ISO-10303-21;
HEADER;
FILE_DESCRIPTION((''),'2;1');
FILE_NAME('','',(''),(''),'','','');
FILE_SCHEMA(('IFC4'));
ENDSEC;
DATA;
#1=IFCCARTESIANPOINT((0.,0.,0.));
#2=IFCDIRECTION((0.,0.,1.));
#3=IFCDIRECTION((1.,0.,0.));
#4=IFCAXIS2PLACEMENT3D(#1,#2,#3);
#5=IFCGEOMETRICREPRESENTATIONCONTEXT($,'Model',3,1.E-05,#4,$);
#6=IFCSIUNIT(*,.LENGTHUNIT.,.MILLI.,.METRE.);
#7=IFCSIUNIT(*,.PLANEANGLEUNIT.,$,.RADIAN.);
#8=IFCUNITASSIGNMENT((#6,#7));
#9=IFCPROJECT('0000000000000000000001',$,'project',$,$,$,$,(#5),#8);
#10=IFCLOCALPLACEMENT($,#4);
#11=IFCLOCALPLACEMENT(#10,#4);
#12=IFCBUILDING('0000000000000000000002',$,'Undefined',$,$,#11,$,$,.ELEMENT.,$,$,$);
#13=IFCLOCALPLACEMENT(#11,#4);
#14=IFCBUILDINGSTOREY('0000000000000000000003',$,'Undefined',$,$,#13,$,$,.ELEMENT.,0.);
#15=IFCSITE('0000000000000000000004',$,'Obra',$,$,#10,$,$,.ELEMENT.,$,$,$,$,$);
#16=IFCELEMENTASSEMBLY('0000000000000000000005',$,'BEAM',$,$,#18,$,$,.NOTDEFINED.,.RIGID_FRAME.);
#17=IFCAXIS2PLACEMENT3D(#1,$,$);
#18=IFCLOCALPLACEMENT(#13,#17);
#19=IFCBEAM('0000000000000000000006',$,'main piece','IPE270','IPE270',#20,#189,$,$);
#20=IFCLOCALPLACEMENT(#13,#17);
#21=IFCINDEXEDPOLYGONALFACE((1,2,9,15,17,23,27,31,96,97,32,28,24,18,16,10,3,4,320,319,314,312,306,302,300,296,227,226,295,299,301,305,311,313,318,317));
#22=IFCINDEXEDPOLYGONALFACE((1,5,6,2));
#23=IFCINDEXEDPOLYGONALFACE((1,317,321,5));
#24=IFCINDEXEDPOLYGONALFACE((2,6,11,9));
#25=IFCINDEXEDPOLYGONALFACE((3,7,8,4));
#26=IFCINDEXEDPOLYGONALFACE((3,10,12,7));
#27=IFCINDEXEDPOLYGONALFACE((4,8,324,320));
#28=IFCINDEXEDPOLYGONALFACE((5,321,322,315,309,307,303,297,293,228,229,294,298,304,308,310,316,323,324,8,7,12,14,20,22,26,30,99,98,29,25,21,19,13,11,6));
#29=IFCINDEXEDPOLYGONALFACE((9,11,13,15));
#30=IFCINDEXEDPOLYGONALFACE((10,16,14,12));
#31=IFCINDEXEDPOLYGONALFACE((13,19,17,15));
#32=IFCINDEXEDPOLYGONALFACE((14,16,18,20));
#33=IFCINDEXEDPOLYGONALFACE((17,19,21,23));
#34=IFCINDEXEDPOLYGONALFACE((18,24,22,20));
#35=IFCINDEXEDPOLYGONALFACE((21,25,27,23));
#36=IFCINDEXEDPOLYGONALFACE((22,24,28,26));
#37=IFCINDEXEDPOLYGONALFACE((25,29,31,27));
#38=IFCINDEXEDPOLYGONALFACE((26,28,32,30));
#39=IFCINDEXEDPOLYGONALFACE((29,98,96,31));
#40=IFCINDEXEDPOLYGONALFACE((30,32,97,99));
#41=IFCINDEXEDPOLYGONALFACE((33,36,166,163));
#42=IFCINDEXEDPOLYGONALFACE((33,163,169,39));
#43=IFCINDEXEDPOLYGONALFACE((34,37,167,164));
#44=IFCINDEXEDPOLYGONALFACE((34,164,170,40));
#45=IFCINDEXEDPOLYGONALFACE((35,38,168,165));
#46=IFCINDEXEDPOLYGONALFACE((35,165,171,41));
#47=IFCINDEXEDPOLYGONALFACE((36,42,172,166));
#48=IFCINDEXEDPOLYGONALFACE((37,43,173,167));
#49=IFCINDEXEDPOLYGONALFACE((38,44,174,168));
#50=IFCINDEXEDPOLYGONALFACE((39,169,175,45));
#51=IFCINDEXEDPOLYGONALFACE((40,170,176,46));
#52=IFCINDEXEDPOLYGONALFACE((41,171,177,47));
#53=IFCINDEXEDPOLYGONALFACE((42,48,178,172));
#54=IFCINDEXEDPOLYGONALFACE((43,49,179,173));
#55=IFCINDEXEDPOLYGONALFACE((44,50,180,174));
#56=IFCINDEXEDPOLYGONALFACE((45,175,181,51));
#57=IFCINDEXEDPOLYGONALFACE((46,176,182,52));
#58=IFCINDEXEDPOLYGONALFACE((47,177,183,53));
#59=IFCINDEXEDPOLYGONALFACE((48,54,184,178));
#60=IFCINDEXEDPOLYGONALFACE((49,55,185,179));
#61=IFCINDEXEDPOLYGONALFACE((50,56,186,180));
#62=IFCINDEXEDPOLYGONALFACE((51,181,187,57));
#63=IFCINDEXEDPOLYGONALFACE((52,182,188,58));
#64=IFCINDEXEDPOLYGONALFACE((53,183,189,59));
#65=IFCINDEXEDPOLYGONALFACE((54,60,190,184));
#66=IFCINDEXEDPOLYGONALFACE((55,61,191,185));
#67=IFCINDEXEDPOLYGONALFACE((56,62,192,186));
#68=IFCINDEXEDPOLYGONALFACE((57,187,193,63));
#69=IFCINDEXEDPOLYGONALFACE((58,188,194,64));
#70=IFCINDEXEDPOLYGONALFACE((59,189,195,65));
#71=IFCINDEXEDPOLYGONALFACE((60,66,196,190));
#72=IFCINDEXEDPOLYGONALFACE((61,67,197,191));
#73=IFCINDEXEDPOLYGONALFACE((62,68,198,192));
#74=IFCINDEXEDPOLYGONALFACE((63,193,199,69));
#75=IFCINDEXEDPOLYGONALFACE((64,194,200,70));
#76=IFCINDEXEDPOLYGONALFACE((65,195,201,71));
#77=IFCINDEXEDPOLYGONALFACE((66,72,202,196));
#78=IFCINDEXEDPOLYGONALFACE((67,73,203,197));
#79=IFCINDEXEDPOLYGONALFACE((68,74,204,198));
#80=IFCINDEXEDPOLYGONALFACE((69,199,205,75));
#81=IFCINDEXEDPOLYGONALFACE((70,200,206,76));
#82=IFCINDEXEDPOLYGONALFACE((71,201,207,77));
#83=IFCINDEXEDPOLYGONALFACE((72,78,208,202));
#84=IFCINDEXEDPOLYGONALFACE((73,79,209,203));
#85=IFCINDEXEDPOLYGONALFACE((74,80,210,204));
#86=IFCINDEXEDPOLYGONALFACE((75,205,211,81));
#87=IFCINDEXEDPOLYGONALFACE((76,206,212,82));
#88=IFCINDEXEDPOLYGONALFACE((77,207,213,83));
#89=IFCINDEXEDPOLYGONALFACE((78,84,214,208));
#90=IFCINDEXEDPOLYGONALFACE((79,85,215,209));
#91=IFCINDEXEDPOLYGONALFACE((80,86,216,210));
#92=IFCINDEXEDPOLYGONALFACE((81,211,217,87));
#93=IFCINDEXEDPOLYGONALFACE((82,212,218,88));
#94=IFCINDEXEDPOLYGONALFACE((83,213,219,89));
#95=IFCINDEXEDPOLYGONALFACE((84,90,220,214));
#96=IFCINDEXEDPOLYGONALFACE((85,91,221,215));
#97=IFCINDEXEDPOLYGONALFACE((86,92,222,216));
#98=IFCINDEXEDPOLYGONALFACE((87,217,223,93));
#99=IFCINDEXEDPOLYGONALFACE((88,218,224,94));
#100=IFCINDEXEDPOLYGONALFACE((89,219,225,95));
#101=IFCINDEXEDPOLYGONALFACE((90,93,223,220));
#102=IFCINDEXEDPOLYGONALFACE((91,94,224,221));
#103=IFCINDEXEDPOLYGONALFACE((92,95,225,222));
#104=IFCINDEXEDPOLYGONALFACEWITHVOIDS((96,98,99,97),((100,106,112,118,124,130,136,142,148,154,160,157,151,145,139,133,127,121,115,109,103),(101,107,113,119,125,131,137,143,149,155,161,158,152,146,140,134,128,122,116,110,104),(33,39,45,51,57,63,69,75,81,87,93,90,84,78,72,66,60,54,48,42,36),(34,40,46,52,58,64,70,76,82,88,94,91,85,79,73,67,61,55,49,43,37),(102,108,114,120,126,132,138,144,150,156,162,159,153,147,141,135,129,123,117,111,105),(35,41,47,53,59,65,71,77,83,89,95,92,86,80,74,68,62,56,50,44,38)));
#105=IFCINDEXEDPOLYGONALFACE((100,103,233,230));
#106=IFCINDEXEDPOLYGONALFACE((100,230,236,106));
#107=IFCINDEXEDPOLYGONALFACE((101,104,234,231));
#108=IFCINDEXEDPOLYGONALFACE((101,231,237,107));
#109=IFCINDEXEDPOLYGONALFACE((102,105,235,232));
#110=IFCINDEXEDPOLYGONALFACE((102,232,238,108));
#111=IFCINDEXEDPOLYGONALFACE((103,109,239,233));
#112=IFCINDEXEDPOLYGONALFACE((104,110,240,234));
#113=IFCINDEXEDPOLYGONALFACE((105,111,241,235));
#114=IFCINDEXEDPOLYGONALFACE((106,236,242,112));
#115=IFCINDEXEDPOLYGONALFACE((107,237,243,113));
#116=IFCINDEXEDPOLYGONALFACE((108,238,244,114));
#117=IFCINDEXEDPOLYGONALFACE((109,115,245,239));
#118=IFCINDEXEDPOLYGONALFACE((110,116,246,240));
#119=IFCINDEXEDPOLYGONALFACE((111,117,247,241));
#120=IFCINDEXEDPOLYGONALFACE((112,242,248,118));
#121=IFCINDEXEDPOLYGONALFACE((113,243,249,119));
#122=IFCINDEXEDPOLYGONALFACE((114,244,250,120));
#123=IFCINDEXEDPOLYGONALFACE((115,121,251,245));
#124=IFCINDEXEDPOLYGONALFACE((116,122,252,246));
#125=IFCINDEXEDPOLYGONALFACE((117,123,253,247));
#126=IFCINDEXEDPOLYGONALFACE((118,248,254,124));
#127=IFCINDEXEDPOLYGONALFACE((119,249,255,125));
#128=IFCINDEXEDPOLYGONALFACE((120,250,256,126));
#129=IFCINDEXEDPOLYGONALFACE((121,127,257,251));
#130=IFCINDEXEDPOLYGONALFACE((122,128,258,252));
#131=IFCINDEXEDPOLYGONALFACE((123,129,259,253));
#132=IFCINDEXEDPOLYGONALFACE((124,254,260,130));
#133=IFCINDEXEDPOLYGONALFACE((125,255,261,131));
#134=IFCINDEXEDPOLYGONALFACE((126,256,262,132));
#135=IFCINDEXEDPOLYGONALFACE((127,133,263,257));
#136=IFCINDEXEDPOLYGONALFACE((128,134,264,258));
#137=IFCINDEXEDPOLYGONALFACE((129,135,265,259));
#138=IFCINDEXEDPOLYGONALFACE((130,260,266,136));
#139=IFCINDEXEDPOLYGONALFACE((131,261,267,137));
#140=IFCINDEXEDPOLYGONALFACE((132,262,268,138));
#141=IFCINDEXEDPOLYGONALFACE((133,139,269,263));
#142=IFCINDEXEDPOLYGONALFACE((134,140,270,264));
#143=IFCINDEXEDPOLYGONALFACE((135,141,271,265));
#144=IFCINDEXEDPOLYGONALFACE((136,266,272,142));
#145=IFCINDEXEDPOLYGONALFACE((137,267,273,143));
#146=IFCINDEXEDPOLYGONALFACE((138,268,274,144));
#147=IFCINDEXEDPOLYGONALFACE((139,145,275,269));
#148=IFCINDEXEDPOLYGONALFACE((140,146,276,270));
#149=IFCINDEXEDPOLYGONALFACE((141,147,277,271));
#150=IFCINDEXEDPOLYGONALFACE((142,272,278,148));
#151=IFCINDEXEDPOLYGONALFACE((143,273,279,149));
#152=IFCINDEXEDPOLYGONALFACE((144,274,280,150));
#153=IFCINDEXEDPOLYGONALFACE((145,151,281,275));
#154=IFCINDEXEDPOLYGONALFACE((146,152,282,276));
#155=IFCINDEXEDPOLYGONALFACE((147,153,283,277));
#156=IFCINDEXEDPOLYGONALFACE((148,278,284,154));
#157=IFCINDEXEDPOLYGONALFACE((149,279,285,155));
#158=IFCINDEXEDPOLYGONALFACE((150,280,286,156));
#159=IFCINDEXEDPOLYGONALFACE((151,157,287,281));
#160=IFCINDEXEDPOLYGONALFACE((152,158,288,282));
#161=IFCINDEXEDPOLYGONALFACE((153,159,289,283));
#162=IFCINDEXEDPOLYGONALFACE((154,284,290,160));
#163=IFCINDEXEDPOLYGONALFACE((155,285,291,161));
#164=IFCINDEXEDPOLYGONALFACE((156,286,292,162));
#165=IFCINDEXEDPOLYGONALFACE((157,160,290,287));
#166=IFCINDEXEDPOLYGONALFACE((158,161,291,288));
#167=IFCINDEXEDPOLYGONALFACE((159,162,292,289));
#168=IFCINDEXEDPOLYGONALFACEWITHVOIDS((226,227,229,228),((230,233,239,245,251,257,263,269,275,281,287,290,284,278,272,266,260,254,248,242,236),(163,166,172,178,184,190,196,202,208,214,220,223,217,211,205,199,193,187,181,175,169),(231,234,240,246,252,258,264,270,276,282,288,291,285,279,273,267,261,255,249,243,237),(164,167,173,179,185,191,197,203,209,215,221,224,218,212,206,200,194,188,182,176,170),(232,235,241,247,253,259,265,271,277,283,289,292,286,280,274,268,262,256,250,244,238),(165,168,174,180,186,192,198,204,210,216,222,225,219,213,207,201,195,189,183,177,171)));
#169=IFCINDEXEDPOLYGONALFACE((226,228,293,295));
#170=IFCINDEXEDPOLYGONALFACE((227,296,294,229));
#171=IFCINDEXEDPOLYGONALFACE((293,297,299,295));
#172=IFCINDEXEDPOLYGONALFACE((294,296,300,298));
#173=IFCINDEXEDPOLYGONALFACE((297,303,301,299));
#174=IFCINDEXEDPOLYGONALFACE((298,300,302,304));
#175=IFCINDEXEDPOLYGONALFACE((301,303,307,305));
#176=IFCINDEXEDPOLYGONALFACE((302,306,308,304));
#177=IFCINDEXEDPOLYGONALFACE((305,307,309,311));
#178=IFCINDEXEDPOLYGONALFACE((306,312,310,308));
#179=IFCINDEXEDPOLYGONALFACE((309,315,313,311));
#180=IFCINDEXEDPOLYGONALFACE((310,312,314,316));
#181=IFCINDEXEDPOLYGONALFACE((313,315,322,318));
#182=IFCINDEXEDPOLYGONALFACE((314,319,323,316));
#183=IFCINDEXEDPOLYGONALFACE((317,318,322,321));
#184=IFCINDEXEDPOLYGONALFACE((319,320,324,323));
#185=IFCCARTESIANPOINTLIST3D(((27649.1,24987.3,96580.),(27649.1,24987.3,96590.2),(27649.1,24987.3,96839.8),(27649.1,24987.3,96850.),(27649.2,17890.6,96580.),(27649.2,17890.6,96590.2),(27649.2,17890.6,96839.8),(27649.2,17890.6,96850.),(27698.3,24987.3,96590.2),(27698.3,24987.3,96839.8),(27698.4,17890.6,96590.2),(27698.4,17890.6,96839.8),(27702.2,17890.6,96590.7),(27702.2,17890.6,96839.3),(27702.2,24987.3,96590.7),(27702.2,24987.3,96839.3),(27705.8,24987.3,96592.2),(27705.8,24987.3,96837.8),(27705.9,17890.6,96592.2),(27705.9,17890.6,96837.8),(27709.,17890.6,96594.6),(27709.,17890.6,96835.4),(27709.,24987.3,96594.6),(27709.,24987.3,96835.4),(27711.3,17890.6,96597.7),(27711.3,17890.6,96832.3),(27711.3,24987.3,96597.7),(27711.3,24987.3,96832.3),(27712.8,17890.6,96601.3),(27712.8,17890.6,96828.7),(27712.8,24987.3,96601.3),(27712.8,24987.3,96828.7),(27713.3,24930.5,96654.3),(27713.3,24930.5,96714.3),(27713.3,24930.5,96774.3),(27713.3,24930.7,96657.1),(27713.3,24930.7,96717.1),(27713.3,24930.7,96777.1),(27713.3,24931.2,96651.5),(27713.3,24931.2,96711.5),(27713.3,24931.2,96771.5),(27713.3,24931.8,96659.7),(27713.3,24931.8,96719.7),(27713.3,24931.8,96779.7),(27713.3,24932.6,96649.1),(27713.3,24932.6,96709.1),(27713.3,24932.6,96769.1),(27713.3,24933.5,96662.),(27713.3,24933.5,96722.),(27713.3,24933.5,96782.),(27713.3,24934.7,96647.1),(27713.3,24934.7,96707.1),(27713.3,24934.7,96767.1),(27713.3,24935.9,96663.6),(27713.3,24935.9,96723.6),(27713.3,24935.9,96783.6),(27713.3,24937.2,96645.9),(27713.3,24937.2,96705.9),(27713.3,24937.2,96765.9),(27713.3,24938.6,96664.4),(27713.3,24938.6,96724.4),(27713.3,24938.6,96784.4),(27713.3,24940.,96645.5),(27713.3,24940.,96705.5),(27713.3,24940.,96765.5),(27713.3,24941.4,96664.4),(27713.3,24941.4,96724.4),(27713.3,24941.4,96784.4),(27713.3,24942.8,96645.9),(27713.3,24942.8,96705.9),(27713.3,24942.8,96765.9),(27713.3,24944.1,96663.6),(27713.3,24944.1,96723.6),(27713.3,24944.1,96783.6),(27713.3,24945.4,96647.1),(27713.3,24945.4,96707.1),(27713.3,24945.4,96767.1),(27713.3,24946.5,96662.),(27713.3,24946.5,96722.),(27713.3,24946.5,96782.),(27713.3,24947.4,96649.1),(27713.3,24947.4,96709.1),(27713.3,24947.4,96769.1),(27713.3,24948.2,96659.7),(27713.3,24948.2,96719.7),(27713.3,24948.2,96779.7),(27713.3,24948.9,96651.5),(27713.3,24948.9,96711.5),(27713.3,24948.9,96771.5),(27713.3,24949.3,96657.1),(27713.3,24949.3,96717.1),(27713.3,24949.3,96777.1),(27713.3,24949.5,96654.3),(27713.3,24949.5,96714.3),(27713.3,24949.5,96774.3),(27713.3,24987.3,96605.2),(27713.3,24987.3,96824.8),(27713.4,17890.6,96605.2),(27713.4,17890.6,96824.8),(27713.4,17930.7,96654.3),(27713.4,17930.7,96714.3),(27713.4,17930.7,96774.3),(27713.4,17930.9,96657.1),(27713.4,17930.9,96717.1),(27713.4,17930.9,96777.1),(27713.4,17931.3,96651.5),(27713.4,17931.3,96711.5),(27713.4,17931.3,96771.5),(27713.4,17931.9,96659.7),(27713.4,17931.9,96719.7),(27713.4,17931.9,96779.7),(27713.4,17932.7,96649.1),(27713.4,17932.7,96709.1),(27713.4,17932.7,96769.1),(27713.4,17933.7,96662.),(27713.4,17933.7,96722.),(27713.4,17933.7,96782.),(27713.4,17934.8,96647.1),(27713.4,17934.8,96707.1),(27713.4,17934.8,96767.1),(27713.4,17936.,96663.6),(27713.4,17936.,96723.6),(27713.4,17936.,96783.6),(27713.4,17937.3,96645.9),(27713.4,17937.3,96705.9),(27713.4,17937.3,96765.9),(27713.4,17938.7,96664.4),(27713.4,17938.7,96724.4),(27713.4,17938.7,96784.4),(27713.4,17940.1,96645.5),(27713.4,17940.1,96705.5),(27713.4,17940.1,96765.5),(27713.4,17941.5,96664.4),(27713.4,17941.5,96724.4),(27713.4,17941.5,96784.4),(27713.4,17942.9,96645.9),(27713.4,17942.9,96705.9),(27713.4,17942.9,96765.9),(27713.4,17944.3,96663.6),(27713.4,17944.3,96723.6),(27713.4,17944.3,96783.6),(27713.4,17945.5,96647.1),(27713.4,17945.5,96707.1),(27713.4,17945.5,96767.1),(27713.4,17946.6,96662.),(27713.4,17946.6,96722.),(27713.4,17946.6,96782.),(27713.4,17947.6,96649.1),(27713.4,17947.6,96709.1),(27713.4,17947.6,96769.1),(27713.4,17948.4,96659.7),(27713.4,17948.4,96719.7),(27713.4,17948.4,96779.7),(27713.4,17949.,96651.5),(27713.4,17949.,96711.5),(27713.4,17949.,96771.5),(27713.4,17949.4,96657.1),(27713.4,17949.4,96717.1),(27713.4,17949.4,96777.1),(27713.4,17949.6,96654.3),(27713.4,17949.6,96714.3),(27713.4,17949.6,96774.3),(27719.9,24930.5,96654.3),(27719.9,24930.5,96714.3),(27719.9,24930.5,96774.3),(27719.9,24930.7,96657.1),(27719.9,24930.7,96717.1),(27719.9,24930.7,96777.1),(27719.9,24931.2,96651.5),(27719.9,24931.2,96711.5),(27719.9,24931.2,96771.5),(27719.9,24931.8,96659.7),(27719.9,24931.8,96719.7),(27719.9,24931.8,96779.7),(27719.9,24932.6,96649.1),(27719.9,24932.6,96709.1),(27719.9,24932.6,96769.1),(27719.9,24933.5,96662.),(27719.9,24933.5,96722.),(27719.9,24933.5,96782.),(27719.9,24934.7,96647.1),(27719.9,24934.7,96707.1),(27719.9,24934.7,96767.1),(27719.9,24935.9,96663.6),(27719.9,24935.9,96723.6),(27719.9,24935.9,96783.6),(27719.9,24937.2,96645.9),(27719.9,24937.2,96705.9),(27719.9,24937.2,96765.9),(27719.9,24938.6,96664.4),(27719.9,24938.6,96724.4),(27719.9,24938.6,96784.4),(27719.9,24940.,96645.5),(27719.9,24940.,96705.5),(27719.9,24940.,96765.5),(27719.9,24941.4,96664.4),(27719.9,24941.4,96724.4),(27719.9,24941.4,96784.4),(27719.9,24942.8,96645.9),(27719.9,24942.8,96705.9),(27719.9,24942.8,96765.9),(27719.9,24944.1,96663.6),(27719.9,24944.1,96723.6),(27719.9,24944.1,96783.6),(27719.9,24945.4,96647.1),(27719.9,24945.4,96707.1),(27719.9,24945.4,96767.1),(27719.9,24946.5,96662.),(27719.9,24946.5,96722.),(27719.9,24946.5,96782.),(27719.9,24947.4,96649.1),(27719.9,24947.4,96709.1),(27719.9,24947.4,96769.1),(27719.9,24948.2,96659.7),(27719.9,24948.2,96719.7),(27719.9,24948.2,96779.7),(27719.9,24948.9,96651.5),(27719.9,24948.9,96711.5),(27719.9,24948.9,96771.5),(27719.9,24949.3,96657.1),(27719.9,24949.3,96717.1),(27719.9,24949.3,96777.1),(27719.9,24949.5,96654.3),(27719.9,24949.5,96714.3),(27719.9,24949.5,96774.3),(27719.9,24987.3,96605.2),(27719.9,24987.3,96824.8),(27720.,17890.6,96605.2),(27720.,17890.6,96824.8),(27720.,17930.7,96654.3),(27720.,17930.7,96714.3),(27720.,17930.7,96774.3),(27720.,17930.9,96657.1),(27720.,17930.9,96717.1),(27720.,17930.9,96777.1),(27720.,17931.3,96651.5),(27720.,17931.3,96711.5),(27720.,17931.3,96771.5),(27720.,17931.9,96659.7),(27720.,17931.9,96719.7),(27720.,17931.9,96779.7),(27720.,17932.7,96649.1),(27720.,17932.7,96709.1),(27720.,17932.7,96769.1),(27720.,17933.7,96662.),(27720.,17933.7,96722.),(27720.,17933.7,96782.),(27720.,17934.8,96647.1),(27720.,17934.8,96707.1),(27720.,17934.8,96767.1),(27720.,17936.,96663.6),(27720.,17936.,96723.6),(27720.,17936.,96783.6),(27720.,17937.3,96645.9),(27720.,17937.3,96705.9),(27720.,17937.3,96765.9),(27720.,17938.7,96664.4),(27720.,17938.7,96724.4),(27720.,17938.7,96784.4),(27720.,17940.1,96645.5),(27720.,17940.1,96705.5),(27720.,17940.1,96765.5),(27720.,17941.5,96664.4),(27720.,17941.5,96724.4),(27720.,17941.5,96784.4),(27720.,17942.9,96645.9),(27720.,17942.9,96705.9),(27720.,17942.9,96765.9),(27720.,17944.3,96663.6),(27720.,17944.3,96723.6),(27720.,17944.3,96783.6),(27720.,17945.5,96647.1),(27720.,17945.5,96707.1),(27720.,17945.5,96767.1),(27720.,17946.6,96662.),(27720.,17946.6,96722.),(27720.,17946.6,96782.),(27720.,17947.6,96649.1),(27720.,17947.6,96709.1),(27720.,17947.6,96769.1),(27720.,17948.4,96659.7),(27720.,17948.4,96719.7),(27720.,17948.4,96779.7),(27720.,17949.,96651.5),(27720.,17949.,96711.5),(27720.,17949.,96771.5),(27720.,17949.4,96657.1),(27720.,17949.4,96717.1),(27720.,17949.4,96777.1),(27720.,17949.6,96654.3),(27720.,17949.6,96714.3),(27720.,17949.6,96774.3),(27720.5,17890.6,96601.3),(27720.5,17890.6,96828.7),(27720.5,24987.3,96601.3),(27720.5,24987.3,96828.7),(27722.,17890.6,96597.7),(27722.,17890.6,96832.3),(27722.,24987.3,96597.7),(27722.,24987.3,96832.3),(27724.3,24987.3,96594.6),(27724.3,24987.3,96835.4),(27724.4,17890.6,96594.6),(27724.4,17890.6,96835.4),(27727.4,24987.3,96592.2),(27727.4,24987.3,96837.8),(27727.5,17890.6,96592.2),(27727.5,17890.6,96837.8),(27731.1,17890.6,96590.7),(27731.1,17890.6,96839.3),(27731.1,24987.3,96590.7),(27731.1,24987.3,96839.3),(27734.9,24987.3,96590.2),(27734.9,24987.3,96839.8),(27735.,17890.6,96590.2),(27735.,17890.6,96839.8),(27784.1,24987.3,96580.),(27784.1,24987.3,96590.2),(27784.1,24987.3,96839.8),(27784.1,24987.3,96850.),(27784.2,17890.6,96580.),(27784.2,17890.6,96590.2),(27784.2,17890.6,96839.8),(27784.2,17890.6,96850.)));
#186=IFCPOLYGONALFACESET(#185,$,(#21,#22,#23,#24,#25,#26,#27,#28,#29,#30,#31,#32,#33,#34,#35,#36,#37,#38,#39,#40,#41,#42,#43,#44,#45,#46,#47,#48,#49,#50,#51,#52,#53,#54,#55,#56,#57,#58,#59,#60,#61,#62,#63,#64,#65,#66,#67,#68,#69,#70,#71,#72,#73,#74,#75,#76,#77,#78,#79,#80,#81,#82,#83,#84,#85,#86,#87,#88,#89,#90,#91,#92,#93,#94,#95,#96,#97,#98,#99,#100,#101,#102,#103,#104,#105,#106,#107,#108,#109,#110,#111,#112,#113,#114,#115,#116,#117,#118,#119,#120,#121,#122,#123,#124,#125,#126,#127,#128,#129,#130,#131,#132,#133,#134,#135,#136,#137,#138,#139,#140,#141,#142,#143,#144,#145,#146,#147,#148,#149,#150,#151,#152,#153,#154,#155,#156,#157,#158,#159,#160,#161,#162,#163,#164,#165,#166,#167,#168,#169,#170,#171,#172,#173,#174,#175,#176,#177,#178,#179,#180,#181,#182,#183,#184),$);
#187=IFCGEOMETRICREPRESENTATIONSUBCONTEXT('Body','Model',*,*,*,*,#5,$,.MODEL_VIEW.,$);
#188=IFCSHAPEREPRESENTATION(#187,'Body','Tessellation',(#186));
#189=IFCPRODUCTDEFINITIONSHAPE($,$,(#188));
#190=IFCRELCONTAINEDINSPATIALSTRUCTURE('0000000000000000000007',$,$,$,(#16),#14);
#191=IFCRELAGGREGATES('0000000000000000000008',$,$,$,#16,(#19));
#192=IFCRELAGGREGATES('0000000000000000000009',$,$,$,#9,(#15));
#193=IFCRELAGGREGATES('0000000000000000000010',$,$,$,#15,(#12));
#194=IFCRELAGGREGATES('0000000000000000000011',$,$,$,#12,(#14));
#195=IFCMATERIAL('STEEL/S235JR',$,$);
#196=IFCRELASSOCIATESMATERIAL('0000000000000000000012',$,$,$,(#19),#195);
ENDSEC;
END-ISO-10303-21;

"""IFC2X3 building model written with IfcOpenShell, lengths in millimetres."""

from ifc_helpers import new_model, si_unit, frame, origin_with_axes, origin_2d_with_axis, place, context, subcontext, project, spatial, circle, i_section, extrude, clip, halfspace, source, transform, mapped, material, element, aggregate, save


model = new_model("IFC2X3")

# Units and contexts
model_context = context("Model", 3, precision=1e-05, world=origin_with_axes())
body_context = subcontext(model_context, "Body", "Model", "MODEL_VIEW")
ifc_project = project(units=[si_unit("LENGTHUNIT", "METRE", prefix="MILLI"), si_unit("PLANEANGLEUNIT", "RADIAN")], contexts=[model_context])

# Site, building, storey
site_placement = place(None, origin_with_axes())
site = spatial("IfcSite", under=ifc_project, at=site_placement, Name="Obra", CompositionType="ELEMENT")
building_placement = place(site_placement, origin_with_axes())
building = spatial("IfcBuilding", under=site, at=building_placement, Name="Undefined", CompositionType="ELEMENT")
storey_placement = place(building_placement, origin_with_axes())
storey = spatial("IfcBuildingStorey", under=building, at=storey_placement, Name="Undefined", CompositionType="ELEMENT", Elevation=0.0)

# Shared definitions
ifc_material = material(Name="STEEL/S235JR")

# Element assembly, beam, openings
assembly_1_placement = place(storey_placement, origin_with_axes())
assembly_1 = element("IfcElementAssembly", 1, at=assembly_1_placement, inside=storey, Name="BEAM", AssemblyPlace="NOTDEFINED", PredefinedType="RIGID_FRAME")
beam_1_placement = place(assembly_1_placement, frame((27716.7, 17630.1, 96715.0), z_axis=(0.0, 0.0, 1.0), x_axis=(-0.000002, 1.0, 0.0)))
beam_1 = element("IfcBeam", 2, at=beam_1_placement, material=ifc_material, Name="main piece", Description="IPE270", ObjectType="IPE270", context=body_context, shape_type="Clipping", body=[
    clip(clip(extrude(i_section(OverallWidth=135.0, OverallDepth=270.0, WebThickness=6.6, FlangeThickness=10.2, FilletRadius=15.0, at=origin_2d_with_axis()), frame((7357.1, 0.0, 0.0), z_axis=(-1.0, 0.0, 0.0), x_axis=(0.0, -1.0, 0.0)), (0.0, 0.0, 1.0), 7357.1), halfspace(frame((260.5, 60.0, -120.0), z_axis=(-1.0, -0.000017, 0.0), x_axis=(0.0, 0.0, 1.0)), False)), halfspace(frame((7359.4, -60.0, -120.0), z_axis=(1.0, 0.000019, 0.0), x_axis=(0.0, 0.0, 1.0)), False)),
])
shared_shape_1 = source(origin_with_axes(), body_context, "Body", "SweptSolid", [
    extrude(circle(Radius=9.5, at=origin_2d_with_axis()), frame((0.0, -3.4, 0.0), z_axis=(0.0, 1.0, 0.0), x_axis=(1.0, 0.0, 0.0)), (0.0, 0.0, 1.0), 6.8),
])
opening_1_placement = place(assembly_1_placement, frame((27716.7, 17890.1, 96835.0), z_axis=(0.0, 1.0, 0.0), x_axis=(0.0, 0.0, -1.0)))
element("IfcOpeningElement", 3, at=opening_1_placement, cuts=beam_1, ObjectType="Opening", context=body_context, shape_type="MappedRepresentation", body=[
    mapped(shared_shape_1, transform((60.0, 0.0, 50.0))),
    mapped(shared_shape_1, transform((120.0, 0.0, 50.0))),
    mapped(shared_shape_1, transform((180.0, 0.0, 50.0))),
])
shared_shape_2 = source(origin_with_axes(), body_context, "Body", "SweptSolid", [
    extrude(circle(Radius=9.5, at=origin_2d_with_axis()), frame((0.0, -3.4, 0.0), z_axis=(0.0, 1.0, 0.0), x_axis=(1.0, 0.0, 0.0)), (0.0, 0.0, 1.0), 6.8),
])
opening_2_placement = place(assembly_1_placement, frame((27716.6, 24990.0, 96835.0), z_axis=(0.000002, -1.0, 0.0), x_axis=(0.0, 0.0, -1.0)))
element("IfcOpeningElement", 4, at=opening_2_placement, cuts=beam_1, ObjectType="Opening", context=body_context, shape_type="MappedRepresentation", body=[
    mapped(shared_shape_2, transform((60.0, 0.0, 50.0))),
    mapped(shared_shape_2, transform((120.0, 0.0, 50.0))),
    mapped(shared_shape_2, transform((180.0, 0.0, 50.0))),
])
aggregate(assembly_1, [beam_1])

save(model, "model.ifc")
